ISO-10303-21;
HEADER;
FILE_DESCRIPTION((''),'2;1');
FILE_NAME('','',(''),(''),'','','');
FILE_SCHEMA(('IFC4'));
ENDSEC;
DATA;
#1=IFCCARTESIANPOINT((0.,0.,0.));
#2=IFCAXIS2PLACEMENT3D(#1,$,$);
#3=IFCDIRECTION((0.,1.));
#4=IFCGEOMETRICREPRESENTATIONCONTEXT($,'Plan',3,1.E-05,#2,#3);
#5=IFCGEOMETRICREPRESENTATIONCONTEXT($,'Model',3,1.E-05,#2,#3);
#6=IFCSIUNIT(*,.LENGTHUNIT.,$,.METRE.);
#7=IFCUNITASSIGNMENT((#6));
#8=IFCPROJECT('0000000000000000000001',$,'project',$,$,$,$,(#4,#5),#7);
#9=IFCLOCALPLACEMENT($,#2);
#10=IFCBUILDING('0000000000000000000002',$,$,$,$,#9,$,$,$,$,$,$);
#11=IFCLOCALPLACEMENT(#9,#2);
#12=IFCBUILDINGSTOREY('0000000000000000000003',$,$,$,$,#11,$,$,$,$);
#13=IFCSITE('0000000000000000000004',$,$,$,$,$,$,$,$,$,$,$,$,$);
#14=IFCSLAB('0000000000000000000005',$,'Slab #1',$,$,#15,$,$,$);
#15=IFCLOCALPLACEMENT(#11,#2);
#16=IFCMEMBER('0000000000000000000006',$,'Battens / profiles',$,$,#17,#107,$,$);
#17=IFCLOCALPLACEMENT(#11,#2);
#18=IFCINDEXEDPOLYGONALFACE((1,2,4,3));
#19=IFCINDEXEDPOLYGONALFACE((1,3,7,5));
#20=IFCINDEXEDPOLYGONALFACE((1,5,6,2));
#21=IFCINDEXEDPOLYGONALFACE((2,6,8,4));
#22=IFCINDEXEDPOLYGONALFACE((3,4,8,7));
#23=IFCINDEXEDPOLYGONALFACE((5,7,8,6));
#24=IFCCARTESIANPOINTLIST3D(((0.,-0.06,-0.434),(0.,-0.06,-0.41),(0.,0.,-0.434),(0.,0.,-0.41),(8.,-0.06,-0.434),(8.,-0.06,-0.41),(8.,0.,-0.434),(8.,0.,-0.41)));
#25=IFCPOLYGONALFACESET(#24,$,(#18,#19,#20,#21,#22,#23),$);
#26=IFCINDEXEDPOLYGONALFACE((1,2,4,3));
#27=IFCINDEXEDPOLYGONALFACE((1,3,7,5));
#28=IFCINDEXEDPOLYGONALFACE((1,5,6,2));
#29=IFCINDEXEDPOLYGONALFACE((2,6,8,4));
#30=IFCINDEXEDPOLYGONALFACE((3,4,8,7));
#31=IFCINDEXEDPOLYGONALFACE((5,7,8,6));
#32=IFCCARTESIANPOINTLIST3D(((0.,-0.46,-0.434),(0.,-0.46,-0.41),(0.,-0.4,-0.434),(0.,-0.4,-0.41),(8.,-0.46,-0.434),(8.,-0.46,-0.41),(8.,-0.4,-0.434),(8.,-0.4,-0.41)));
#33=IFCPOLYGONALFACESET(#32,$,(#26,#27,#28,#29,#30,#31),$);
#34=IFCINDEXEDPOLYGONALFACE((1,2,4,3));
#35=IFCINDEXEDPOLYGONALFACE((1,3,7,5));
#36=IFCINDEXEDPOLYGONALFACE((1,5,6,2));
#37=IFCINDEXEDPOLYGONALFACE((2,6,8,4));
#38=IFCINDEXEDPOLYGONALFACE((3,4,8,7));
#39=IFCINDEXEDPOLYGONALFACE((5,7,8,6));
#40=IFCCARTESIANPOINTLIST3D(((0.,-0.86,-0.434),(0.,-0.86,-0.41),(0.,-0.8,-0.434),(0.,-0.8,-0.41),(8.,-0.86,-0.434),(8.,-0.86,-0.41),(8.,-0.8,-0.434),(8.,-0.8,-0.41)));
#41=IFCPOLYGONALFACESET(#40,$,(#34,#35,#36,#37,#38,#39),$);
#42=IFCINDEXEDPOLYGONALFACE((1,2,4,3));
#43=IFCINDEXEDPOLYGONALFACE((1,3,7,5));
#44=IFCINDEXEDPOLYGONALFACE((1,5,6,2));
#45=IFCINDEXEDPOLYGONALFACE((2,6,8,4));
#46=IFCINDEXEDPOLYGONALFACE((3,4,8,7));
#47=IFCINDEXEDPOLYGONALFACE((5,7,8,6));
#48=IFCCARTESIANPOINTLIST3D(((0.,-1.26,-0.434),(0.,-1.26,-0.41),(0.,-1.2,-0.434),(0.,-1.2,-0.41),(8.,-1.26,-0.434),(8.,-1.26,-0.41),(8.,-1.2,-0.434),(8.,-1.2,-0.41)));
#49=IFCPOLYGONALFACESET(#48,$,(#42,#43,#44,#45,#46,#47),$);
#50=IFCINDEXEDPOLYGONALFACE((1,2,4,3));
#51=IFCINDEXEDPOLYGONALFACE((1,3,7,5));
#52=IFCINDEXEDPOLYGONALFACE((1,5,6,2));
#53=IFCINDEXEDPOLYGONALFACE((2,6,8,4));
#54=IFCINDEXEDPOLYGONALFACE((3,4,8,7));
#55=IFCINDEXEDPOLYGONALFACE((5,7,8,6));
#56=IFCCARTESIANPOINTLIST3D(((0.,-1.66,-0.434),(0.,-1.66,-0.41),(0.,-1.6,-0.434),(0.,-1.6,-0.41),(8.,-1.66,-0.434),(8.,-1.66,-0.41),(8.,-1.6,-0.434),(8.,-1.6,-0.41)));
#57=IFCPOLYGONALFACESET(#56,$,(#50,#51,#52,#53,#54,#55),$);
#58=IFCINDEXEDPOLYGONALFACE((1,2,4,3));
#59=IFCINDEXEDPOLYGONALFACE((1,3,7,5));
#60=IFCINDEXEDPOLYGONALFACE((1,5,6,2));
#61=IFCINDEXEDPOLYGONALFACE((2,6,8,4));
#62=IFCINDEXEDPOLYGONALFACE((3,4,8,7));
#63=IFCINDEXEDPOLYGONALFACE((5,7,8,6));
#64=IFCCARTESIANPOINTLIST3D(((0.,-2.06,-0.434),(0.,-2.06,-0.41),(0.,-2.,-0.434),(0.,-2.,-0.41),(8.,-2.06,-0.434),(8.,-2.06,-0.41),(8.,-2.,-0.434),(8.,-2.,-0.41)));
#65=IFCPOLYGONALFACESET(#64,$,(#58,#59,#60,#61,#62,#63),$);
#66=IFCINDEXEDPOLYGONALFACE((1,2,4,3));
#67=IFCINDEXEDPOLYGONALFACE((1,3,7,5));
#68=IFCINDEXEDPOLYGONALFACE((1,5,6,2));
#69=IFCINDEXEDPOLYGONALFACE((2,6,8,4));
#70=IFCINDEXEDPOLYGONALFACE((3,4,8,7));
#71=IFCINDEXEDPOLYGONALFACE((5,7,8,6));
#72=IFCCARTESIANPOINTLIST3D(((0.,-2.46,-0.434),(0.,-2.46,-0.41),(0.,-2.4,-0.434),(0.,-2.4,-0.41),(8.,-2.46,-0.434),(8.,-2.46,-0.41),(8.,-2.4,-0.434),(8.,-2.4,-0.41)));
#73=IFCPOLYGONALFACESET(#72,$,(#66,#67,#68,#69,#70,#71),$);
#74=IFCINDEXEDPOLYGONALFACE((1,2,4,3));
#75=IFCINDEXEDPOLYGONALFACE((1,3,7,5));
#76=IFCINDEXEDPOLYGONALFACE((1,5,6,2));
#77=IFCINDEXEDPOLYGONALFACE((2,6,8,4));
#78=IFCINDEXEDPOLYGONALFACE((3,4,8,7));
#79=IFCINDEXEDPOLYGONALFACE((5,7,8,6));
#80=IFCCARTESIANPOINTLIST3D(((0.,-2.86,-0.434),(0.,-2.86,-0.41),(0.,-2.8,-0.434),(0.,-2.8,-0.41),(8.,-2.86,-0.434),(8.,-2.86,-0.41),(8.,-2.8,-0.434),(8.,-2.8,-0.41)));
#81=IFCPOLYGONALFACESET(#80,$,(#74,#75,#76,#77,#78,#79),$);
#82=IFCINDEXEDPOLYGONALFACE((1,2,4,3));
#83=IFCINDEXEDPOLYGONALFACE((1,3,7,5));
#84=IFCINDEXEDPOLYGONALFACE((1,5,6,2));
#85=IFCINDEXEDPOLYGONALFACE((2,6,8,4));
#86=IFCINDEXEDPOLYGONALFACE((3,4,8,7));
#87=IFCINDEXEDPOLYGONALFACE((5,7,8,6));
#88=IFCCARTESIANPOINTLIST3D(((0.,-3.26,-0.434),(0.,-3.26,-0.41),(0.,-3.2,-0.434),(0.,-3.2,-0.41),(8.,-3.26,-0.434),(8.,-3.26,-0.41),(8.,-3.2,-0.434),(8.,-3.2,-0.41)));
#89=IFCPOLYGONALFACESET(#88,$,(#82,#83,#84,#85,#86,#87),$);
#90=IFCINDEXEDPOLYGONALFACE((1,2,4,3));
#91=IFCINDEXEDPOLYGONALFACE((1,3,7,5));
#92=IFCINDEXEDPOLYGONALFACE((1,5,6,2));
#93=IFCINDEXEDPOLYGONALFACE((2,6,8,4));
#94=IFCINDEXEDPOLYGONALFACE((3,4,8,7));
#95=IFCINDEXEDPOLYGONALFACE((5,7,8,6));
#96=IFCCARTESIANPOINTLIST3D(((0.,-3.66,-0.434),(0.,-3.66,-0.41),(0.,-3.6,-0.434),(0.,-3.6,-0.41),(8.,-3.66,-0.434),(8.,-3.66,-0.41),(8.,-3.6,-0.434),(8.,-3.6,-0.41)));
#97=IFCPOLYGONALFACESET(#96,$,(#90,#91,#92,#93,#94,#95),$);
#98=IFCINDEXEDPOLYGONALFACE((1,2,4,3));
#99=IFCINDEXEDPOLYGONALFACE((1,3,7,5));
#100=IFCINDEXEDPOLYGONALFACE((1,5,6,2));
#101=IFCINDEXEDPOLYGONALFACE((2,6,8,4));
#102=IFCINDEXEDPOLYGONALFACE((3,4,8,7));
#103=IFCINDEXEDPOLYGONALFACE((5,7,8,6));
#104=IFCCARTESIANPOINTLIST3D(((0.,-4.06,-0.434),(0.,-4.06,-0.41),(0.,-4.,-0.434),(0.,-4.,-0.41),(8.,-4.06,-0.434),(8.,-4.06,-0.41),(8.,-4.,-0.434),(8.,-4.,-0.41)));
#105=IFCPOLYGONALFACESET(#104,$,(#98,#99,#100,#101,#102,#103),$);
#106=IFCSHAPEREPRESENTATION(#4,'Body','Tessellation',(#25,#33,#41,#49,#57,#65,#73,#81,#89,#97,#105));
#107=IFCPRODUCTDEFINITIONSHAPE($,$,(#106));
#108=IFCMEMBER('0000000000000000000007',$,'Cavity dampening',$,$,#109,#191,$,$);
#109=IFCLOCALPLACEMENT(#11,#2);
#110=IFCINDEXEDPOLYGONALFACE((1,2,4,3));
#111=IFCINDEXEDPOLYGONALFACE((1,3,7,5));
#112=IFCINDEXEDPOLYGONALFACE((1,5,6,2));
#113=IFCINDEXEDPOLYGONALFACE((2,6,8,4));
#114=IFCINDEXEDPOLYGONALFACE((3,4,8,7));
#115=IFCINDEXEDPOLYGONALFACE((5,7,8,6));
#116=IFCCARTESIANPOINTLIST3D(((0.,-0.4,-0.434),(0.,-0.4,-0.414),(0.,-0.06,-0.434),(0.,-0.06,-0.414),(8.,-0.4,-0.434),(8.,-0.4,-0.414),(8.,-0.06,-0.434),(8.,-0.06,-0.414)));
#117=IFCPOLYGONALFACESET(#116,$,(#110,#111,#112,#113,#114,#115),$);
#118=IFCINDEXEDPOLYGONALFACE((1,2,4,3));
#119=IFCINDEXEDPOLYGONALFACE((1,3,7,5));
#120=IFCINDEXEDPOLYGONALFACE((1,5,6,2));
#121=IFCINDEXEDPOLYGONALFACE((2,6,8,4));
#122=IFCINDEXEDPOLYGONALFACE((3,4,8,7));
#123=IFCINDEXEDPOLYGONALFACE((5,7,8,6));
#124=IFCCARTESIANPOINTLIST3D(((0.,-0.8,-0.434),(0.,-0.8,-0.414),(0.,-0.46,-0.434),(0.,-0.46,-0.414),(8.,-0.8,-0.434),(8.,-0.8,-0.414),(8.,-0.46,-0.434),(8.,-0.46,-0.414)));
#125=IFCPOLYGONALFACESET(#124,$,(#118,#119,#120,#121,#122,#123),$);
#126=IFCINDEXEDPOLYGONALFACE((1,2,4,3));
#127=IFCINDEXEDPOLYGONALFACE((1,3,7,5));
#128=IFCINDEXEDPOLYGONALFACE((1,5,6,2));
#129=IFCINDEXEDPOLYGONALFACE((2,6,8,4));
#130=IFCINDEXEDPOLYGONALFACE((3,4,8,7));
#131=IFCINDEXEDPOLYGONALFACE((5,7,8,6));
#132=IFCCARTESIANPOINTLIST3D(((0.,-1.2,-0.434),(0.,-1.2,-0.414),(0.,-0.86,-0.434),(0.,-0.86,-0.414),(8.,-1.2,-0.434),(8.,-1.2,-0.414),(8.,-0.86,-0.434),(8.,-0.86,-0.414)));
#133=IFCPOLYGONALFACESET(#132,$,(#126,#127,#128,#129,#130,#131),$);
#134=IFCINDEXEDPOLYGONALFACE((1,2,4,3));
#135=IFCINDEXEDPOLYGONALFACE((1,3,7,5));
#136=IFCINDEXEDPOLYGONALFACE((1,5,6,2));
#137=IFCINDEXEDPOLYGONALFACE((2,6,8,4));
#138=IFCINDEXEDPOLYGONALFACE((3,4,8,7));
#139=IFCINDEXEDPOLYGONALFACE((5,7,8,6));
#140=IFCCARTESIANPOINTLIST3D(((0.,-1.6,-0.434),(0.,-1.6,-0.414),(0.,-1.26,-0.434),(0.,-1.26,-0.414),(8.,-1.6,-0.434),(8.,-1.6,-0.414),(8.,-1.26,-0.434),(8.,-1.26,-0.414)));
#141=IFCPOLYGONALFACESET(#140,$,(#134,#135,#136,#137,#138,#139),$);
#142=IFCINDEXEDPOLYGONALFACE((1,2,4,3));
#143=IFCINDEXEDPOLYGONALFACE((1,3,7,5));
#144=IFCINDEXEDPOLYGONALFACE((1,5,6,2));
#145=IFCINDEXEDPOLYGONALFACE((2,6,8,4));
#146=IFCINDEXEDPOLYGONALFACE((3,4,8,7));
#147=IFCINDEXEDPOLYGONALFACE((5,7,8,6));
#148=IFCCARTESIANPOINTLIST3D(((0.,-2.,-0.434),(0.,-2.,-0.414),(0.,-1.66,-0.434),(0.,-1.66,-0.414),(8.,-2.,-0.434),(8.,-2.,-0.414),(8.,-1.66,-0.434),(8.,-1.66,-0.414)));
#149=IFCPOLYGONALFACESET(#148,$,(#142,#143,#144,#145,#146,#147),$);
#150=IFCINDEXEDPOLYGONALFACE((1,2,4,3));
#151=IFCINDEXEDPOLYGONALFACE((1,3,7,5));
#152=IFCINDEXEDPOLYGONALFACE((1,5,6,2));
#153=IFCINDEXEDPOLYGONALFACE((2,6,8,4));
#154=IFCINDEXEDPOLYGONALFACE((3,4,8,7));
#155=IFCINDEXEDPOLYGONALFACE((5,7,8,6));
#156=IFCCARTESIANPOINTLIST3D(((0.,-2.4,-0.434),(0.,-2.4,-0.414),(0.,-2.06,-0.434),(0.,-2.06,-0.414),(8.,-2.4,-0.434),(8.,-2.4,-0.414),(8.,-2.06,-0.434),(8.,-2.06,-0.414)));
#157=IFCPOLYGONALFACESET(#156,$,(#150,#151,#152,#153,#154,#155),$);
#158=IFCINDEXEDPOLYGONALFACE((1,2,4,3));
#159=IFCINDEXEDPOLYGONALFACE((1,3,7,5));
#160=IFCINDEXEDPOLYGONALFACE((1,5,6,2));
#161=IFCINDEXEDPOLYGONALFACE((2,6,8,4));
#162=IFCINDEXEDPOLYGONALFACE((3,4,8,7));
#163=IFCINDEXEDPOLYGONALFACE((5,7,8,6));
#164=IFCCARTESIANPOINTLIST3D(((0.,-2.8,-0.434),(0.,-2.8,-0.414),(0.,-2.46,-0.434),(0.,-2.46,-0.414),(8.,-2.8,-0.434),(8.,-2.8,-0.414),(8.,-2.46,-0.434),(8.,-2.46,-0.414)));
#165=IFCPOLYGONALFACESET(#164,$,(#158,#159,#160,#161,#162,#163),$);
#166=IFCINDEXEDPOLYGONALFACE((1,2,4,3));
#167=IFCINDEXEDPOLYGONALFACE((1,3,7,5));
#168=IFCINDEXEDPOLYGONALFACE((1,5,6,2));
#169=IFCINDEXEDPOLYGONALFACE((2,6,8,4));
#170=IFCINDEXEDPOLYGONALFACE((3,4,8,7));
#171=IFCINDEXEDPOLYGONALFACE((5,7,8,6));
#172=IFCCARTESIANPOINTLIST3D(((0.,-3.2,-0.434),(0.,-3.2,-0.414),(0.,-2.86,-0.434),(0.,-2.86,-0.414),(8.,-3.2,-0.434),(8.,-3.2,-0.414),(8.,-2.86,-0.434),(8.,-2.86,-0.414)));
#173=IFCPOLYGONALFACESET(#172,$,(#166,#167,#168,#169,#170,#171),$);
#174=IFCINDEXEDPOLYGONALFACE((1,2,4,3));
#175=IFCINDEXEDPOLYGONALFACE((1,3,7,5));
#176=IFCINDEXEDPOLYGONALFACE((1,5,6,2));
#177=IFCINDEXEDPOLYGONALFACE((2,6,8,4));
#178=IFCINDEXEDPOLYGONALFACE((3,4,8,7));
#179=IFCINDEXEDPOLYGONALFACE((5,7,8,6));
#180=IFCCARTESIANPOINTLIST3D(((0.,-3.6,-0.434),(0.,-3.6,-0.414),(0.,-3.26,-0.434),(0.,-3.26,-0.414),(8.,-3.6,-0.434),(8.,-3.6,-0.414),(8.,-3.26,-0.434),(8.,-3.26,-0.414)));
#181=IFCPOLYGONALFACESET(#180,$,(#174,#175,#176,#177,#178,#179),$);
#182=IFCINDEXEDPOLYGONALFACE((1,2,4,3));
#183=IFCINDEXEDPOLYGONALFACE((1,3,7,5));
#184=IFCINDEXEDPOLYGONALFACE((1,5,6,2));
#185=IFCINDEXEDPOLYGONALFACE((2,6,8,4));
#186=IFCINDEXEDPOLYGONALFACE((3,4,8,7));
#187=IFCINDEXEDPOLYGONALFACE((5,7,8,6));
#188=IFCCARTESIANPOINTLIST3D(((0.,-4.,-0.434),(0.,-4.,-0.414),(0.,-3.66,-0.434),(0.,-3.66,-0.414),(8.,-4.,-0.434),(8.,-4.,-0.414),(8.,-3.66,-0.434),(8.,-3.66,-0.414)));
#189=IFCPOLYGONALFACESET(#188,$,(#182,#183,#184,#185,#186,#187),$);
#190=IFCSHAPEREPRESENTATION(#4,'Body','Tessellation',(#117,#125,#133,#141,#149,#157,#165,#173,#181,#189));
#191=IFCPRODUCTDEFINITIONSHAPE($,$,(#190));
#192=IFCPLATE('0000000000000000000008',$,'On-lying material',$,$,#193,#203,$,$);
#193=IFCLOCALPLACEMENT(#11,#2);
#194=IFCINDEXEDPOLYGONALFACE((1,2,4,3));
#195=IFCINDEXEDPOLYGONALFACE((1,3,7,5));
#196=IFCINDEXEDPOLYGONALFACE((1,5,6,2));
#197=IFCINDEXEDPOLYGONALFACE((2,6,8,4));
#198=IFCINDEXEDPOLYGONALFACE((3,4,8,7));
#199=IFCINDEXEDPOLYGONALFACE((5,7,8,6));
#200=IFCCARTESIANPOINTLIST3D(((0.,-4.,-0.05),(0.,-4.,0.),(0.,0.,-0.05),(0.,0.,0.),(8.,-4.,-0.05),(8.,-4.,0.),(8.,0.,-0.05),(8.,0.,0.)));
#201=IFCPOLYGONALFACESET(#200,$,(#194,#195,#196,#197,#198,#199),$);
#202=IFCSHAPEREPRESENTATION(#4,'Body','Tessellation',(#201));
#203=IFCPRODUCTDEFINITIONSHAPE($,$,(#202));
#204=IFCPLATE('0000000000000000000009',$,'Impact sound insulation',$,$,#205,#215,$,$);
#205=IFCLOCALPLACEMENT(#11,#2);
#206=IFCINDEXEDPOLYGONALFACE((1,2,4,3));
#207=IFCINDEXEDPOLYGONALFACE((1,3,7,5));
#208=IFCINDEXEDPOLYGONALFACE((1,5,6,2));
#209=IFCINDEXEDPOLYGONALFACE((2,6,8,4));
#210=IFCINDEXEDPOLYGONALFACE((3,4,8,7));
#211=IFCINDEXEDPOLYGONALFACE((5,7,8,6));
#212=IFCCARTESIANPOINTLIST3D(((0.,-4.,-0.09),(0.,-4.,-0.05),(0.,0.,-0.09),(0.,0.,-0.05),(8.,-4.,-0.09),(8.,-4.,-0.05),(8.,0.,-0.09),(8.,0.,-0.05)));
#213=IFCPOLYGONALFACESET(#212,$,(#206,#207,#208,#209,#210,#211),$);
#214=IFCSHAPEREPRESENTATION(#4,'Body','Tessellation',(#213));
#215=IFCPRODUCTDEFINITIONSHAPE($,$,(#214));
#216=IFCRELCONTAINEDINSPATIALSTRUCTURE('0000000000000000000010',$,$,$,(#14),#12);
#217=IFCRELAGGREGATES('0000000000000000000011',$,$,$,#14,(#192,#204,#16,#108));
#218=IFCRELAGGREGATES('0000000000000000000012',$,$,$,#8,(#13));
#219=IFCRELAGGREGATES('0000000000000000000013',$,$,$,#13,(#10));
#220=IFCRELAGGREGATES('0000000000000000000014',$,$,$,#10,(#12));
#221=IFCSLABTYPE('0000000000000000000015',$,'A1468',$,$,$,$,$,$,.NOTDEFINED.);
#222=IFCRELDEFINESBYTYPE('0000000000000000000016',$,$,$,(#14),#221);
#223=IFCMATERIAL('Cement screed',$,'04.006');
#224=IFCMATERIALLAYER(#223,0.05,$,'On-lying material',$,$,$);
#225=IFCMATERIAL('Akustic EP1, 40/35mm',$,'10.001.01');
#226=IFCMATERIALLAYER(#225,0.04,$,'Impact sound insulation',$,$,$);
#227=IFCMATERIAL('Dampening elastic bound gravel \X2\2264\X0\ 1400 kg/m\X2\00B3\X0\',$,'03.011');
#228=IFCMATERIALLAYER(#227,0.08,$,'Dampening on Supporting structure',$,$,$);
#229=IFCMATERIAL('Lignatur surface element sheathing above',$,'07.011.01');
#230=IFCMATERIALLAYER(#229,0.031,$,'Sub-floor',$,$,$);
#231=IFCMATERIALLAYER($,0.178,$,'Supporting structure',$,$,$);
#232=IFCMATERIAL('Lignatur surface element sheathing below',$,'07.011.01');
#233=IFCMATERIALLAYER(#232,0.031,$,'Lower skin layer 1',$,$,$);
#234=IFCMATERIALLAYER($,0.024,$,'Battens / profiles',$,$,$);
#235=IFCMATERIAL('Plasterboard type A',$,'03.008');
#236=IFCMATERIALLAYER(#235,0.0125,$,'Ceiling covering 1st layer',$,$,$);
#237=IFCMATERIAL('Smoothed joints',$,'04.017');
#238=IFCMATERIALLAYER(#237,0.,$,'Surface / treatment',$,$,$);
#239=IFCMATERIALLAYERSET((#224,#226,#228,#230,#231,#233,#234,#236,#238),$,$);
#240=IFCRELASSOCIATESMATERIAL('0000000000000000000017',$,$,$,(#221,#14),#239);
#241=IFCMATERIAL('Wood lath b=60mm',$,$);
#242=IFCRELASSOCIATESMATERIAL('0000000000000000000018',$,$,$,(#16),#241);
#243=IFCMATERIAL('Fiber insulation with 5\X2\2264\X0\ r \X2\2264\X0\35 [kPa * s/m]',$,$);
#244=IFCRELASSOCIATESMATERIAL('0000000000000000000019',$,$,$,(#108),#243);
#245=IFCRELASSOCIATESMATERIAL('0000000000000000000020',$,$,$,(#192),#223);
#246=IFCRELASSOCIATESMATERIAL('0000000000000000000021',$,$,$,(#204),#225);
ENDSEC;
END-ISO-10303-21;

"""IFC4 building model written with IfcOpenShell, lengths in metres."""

from ifc_helpers import new_model, si_unit, direction, frame, frame_2d, origin, origin_with_axes, place, context, project, spatial, rectangle, extrude, material, layer, layer_set, type_object, element, aggregate, save


model = new_model("IFC4")

# Units and contexts
plan_context = context("Plan", 3, precision=1e-05, world=origin(), true_north=direction((0.0, 1.0)))
model_context = context("Model", 3, precision=1e-05, world=origin(), true_north=direction((0.0, 1.0)))
ifc_project = project(units=[si_unit("LENGTHUNIT", "METRE")], contexts=[plan_context, model_context])

# Site, building, storey
site = spatial("IfcSite", under=ifc_project)
building_placement = place(None, origin())
building = spatial("IfcBuilding", under=site, at=building_placement)
storey_placement = place(building_placement, origin())
storey = spatial("IfcBuildingStorey", under=building, at=storey_placement)

# Slab, members, plates
ifc_material_1 = material(Name="Cement screed", Category="04.006")
ifc_layer_1 = layer(ifc_material_1, 0.05, Name="On-lying material")
ifc_material_2 = material(Name="Akustic EP1, 40/35mm", Category="10.001.01")
ifc_layer_2 = layer(ifc_material_2, 0.04, Name="Impact sound insulation")
ifc_material_3 = material(Name="Dampening elastic bound gravel ≤ 1400 kg/m³", Category="03.011")
ifc_layer_3 = layer(ifc_material_3, 0.08, Name="Dampening on Supporting structure")
ifc_material_4 = material(Name="Lignatur surface element sheathing above", Category="07.011.01")
ifc_layer_4 = layer(ifc_material_4, 0.031, Name="Sub-floor")
ifc_layer_5 = layer(None, 0.178, Name="Supporting structure")
ifc_material_5 = material(Name="Lignatur surface element sheathing below", Category="07.011.01")
ifc_layer_6 = layer(ifc_material_5, 0.031, Name="Lower skin layer 1")
ifc_layer_7 = layer(None, 0.024, Name="Battens / profiles")
ifc_material_6 = material(Name="Plasterboard type A", Category="03.008")
ifc_layer_8 = layer(ifc_material_6, 0.0125, Name="Ceiling covering 1st layer")
ifc_material_7 = material(Name="Smoothed joints", Category="04.017")
ifc_layer_9 = layer(ifc_material_7, 0.0, Name="Surface / treatment")
ifc_layer_set = layer_set([ifc_layer_1, ifc_layer_2, ifc_layer_3, ifc_layer_4, ifc_layer_5, ifc_layer_6, ifc_layer_7, ifc_layer_8, ifc_layer_9])
slab_type = type_object("IfcSlabType", Name="A1468", PredefinedType="NOTDEFINED", material=ifc_layer_set)
slab_placement = place(None, frame((0.0, 0.0, 0.0), z_axis=(0.0, 0.0, -1.0), x_axis=(1.0, 0.0, 0.0)))
slab = element("IfcSlab", 1, at=slab_placement, inside=storey, type_object=slab_type, material=ifc_layer_set, Name="Slab #1")
ifc_material_8 = material(Name="Wood lath b=60mm")
member_1_placement = place(slab_placement, origin())
member_1 = element("IfcMember", 2, at=member_1_placement, material=ifc_material_8, Name="Battens / profiles", context=plan_context, shape_type="SweptSolid", body=[
    extrude(rectangle(XDim=0.06, YDim=0.024, at=frame_2d((0.03, 0.012), x_axis=(1.0, 0.0))), frame((0.0, 0.0, 0.41), z_axis=(1.0, 0.0, 0.0), x_axis=(0.0, 1.0, 0.0)), (0.0, 0.0, 1.0), 8.0),
    extrude(rectangle(XDim=0.06, YDim=0.024, at=frame_2d((0.03, 0.012), x_axis=(1.0, 0.0))), frame((0.0, 0.4, 0.41), z_axis=(1.0, 0.0, 0.0), x_axis=(0.0, 1.0, 0.0)), (0.0, 0.0, 1.0), 8.0),
    extrude(rectangle(XDim=0.06, YDim=0.024, at=frame_2d((0.03, 0.012), x_axis=(1.0, 0.0))), frame((0.0, 0.8, 0.41), z_axis=(1.0, 0.0, 0.0), x_axis=(0.0, 1.0, 0.0)), (0.0, 0.0, 1.0), 8.0),
    extrude(rectangle(XDim=0.06, YDim=0.024, at=frame_2d((0.03, 0.012), x_axis=(1.0, 0.0))), frame((0.0, 1.2, 0.41), z_axis=(1.0, 0.0, 0.0), x_axis=(0.0, 1.0, 0.0)), (0.0, 0.0, 1.0), 8.0),
    extrude(rectangle(XDim=0.06, YDim=0.024, at=frame_2d((0.03, 0.012), x_axis=(1.0, 0.0))), frame((0.0, 1.6, 0.41), z_axis=(1.0, 0.0, 0.0), x_axis=(0.0, 1.0, 0.0)), (0.0, 0.0, 1.0), 8.0),
    extrude(rectangle(XDim=0.06, YDim=0.024, at=frame_2d((0.03, 0.012), x_axis=(1.0, 0.0))), frame((0.0, 2.0, 0.41), z_axis=(1.0, 0.0, 0.0), x_axis=(0.0, 1.0, 0.0)), (0.0, 0.0, 1.0), 8.0),
    extrude(rectangle(XDim=0.06, YDim=0.024, at=frame_2d((0.03, 0.012), x_axis=(1.0, 0.0))), frame((0.0, 2.4, 0.41), z_axis=(1.0, 0.0, 0.0), x_axis=(0.0, 1.0, 0.0)), (0.0, 0.0, 1.0), 8.0),
    extrude(rectangle(XDim=0.06, YDim=0.024, at=frame_2d((0.03, 0.012), x_axis=(1.0, 0.0))), frame((0.0, 2.8, 0.41), z_axis=(1.0, 0.0, 0.0), x_axis=(0.0, 1.0, 0.0)), (0.0, 0.0, 1.0), 8.0),
    extrude(rectangle(XDim=0.06, YDim=0.024, at=frame_2d((0.03, 0.012), x_axis=(1.0, 0.0))), frame((0.0, 3.2, 0.41), z_axis=(1.0, 0.0, 0.0), x_axis=(0.0, 1.0, 0.0)), (0.0, 0.0, 1.0), 8.0),
    extrude(rectangle(XDim=0.06, YDim=0.024, at=frame_2d((0.03, 0.012), x_axis=(1.0, 0.0))), frame((0.0, 3.6, 0.41), z_axis=(1.0, 0.0, 0.0), x_axis=(0.0, 1.0, 0.0)), (0.0, 0.0, 1.0), 8.0),
    extrude(rectangle(XDim=0.06, YDim=0.024, at=frame_2d((0.03, 0.012), x_axis=(1.0, 0.0))), frame((0.0, 4.0, 0.41), z_axis=(1.0, 0.0, 0.0), x_axis=(0.0, 1.0, 0.0)), (0.0, 0.0, 1.0), 8.0),
])
ifc_material_9 = material(Name="Fiber insulation with 5≤ r ≤35 [kPa * s/m]")
member_2_placement = place(slab_placement, origin())
member_2 = element("IfcMember", 3, at=member_2_placement, material=ifc_material_9, Name="Cavity dampening", context=plan_context, shape_type="SweptSolid", body=[
    extrude(rectangle(XDim=0.34, YDim=0.02, at=frame_2d((0.17, 0.01), x_axis=(1.0, 0.0))), frame((0.0, 0.06, 0.414), z_axis=(1.0, 0.0, 0.0), x_axis=(0.0, 1.0, 0.0)), (0.0, 0.0, 1.0), 8.0),
    extrude(rectangle(XDim=0.34, YDim=0.02, at=frame_2d((0.17, 0.01), x_axis=(1.0, 0.0))), frame((0.0, 0.46, 0.414), z_axis=(1.0, 0.0, 0.0), x_axis=(0.0, 1.0, 0.0)), (0.0, 0.0, 1.0), 8.0),
    extrude(rectangle(XDim=0.34, YDim=0.02, at=frame_2d((0.17, 0.01), x_axis=(1.0, 0.0))), frame((0.0, 0.86, 0.414), z_axis=(1.0, 0.0, 0.0), x_axis=(0.0, 1.0, 0.0)), (0.0, 0.0, 1.0), 8.0),
    extrude(rectangle(XDim=0.34, YDim=0.02, at=frame_2d((0.17, 0.01), x_axis=(1.0, 0.0))), frame((0.0, 1.26, 0.414), z_axis=(1.0, 0.0, 0.0), x_axis=(0.0, 1.0, 0.0)), (0.0, 0.0, 1.0), 8.0),
    extrude(rectangle(XDim=0.34, YDim=0.02, at=frame_2d((0.17, 0.01), x_axis=(1.0, 0.0))), frame((0.0, 1.66, 0.414), z_axis=(1.0, 0.0, 0.0), x_axis=(0.0, 1.0, 0.0)), (0.0, 0.0, 1.0), 8.0),
    extrude(rectangle(XDim=0.34, YDim=0.02, at=frame_2d((0.17, 0.01), x_axis=(1.0, 0.0))), frame((0.0, 2.06, 0.414), z_axis=(1.0, 0.0, 0.0), x_axis=(0.0, 1.0, 0.0)), (0.0, 0.0, 1.0), 8.0),
    extrude(rectangle(XDim=0.34, YDim=0.02, at=frame_2d((0.17, 0.01), x_axis=(1.0, 0.0))), frame((0.0, 2.46, 0.414), z_axis=(1.0, 0.0, 0.0), x_axis=(0.0, 1.0, 0.0)), (0.0, 0.0, 1.0), 8.0),
    extrude(rectangle(XDim=0.34, YDim=0.02, at=frame_2d((0.17, 0.01), x_axis=(1.0, 0.0))), frame((0.0, 2.86, 0.414), z_axis=(1.0, 0.0, 0.0), x_axis=(0.0, 1.0, 0.0)), (0.0, 0.0, 1.0), 8.0),
    extrude(rectangle(XDim=0.34, YDim=0.02, at=frame_2d((0.17, 0.01), x_axis=(1.0, 0.0))), frame((0.0, 3.26, 0.414), z_axis=(1.0, 0.0, 0.0), x_axis=(0.0, 1.0, 0.0)), (0.0, 0.0, 1.0), 8.0),
    extrude(rectangle(XDim=0.34, YDim=0.02, at=frame_2d((0.17, 0.01), x_axis=(1.0, 0.0))), frame((0.0, 3.66, 0.414), z_axis=(1.0, 0.0, 0.0), x_axis=(0.0, 1.0, 0.0)), (0.0, 0.0, 1.0), 8.0),
])
plate_1_placement = place(slab_placement, origin())
plate_1 = element("IfcPlate", 4, at=plate_1_placement, material=ifc_material_1, Name="On-lying material", context=plan_context, shape_type="SweptSolid", body=[
    extrude(rectangle(XDim=8.0, YDim=4.0, at=frame_2d((4.0, 2.0), x_axis=(1.0, 0.0))), origin_with_axes(), (0.0, 0.0, 1.0), 0.05),
])
plate_2_placement = place(slab_placement, origin())
plate_2 = element("IfcPlate", 5, at=plate_2_placement, material=ifc_material_2, Name="Impact sound insulation", context=plan_context, shape_type="SweptSolid", body=[
    extrude(rectangle(XDim=8.0, YDim=4.0, at=frame_2d((4.0, 2.0), x_axis=(1.0, 0.0))), frame((0.0, 0.0, 0.05), z_axis=(0.0, 0.0, 1.0), x_axis=(1.0, 0.0, 0.0)), (0.0, 0.0, 1.0), 0.04),
])
aggregate(slab, [plate_1, plate_2, member_1, member_2])

save(model, "model.ifc")
